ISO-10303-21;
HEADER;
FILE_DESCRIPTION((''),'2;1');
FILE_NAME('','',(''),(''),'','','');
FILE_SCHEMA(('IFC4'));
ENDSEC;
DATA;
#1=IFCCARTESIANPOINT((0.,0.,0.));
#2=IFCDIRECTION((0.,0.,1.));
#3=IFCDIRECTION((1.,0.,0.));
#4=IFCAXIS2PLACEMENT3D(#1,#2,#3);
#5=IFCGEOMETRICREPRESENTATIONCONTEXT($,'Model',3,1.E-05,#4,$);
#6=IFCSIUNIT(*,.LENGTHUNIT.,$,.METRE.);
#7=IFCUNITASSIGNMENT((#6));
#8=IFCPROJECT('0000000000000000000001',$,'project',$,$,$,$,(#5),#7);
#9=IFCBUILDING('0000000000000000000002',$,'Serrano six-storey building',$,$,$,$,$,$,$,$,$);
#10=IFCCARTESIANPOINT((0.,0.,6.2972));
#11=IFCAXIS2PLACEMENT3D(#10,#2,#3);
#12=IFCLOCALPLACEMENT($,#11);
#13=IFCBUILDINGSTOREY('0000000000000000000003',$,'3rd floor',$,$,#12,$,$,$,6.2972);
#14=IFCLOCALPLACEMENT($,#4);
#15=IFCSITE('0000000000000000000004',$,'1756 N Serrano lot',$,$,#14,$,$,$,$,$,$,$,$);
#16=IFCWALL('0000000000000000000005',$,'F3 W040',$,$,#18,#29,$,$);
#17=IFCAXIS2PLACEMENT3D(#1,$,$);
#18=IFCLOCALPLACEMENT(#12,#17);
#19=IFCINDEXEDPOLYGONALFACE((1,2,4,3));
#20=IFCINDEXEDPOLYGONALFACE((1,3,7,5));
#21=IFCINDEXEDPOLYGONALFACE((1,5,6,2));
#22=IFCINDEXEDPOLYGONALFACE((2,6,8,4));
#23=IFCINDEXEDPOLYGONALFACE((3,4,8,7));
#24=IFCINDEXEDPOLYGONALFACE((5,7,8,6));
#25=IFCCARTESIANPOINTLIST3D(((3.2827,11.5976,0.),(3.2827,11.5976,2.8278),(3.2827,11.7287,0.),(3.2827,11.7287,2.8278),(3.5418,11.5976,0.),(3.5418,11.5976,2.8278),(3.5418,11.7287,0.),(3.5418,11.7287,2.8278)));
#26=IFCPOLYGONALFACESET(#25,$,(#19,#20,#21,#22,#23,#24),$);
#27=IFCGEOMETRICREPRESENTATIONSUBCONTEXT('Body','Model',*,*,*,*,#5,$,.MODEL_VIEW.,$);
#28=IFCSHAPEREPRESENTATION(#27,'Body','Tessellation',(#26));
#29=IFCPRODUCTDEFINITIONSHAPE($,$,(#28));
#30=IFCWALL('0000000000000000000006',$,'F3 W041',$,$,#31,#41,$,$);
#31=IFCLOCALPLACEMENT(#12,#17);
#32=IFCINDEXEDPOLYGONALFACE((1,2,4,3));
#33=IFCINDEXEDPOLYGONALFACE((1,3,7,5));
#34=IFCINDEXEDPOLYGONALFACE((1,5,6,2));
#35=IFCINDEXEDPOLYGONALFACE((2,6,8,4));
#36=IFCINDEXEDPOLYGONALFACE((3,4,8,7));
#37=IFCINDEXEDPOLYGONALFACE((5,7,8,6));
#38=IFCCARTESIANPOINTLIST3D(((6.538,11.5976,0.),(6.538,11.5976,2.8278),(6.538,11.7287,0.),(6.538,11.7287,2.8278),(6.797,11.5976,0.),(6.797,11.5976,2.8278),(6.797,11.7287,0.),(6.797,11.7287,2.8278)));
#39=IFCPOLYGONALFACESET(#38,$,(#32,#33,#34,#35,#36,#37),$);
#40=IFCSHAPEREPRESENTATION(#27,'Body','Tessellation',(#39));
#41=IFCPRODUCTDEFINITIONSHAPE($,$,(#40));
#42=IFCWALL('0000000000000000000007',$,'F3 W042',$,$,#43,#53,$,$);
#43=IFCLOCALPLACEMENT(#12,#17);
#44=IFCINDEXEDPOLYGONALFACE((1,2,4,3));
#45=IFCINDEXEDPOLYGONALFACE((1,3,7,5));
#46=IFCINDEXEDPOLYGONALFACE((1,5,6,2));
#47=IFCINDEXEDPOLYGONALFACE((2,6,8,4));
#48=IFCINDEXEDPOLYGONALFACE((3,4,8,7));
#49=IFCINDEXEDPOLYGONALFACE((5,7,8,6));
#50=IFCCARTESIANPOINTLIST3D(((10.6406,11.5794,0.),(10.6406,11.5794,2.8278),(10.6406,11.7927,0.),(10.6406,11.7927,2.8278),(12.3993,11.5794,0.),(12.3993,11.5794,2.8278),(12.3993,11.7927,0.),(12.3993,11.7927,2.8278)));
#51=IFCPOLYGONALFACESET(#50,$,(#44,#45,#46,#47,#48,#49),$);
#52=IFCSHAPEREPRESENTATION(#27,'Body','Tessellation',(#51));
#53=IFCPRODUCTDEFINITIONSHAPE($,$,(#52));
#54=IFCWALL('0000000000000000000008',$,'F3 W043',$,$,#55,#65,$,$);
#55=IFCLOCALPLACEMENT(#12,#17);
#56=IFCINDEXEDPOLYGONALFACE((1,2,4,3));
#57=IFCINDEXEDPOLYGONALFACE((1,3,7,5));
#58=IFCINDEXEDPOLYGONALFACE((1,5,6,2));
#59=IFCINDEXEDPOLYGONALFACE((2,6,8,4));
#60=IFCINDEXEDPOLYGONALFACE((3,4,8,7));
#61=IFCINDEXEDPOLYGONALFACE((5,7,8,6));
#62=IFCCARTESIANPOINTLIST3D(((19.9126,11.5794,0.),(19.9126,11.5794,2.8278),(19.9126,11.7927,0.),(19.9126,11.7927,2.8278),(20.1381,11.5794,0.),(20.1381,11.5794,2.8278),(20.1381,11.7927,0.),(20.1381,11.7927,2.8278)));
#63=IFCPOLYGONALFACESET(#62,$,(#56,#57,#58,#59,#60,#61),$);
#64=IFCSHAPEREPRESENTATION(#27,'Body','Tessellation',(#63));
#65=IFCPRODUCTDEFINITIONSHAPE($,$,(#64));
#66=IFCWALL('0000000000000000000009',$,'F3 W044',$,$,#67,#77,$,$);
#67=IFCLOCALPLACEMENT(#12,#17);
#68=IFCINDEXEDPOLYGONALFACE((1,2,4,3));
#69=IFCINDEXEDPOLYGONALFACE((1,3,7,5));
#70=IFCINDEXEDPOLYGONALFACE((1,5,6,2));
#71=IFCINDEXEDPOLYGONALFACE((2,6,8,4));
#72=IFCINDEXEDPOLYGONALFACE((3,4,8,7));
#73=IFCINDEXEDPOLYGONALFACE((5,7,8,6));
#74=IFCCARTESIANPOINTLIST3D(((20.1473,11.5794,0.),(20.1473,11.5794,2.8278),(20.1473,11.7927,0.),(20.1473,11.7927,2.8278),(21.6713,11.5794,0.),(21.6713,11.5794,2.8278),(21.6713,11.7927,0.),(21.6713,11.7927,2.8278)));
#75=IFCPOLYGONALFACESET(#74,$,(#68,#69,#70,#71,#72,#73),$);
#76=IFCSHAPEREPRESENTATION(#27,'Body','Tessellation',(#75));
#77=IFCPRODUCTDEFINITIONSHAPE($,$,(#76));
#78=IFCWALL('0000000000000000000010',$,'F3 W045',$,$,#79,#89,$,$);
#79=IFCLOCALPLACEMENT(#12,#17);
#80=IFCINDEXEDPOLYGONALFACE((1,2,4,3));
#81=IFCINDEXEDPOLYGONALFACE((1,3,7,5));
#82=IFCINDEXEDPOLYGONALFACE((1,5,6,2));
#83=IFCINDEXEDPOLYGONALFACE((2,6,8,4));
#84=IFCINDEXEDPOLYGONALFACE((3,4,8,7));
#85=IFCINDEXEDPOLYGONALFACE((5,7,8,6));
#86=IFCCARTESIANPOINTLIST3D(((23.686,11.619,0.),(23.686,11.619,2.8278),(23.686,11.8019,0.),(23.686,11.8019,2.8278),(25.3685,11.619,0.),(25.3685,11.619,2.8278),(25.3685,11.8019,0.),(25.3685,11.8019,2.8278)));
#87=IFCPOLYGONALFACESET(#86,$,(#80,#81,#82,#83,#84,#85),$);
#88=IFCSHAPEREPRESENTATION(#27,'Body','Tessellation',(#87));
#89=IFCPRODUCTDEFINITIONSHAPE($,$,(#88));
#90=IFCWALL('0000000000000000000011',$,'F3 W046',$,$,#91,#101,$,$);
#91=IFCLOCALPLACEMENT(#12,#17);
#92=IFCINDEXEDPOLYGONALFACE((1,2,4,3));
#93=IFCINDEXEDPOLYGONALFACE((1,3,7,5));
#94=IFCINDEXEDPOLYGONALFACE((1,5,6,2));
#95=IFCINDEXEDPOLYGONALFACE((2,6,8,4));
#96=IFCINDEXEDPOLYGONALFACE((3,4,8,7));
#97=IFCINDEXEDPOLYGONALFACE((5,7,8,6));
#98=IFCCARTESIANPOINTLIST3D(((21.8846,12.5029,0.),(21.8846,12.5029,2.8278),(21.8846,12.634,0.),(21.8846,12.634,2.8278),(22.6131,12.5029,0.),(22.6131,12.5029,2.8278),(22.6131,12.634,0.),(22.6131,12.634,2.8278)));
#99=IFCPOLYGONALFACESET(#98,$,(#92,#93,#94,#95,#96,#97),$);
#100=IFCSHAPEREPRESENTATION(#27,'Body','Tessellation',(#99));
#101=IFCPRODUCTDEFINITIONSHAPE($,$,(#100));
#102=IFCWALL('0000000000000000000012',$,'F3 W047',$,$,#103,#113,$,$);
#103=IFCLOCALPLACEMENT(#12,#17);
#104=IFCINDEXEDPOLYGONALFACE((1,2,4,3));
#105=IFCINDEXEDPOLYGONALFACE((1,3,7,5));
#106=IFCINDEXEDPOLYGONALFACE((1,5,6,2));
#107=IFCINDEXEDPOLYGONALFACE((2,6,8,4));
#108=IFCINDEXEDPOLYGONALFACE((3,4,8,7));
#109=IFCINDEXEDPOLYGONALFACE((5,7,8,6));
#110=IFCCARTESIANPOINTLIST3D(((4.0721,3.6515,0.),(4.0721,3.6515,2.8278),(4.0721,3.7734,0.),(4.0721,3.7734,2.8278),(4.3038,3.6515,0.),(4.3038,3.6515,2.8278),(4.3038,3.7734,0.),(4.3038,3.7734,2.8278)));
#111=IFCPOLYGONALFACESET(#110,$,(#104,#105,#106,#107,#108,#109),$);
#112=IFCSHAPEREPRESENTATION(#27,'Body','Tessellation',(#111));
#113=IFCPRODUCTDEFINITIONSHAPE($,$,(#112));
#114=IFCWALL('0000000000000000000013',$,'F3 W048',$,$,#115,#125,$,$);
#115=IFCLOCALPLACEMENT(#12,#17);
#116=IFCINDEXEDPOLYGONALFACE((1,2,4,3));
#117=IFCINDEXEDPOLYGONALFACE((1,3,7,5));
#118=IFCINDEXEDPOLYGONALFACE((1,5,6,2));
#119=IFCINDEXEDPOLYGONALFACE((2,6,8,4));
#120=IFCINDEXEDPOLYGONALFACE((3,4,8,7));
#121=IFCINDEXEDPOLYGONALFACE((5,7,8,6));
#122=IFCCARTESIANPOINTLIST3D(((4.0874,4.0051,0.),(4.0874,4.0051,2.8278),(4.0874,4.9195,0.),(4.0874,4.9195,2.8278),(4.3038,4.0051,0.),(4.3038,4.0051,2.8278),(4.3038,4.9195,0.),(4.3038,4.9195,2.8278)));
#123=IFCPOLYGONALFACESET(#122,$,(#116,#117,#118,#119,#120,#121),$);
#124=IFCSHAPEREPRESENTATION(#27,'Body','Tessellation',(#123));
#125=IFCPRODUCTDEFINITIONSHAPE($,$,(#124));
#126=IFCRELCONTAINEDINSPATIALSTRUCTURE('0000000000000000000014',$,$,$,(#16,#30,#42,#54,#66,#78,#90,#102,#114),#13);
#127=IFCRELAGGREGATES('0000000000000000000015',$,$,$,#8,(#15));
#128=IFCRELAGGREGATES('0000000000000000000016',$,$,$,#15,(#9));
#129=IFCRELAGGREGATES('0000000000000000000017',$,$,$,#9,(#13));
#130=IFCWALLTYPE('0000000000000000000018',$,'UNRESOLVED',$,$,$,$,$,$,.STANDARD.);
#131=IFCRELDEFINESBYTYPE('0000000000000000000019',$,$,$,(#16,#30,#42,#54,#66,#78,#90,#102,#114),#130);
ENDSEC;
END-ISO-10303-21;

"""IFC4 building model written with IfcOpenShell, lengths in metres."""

from ifc_helpers import new_model, si_unit, frame, origin_with_axes, place, context, subcontext, project, spatial, polyline, outline, extrude, type_object, element, save


model = new_model("IFC4")

# Units and contexts
model_context = context("Model", 3, precision=1e-05, world=origin_with_axes())
body_context = subcontext(model_context, "Body", "Model", "MODEL_VIEW")
ifc_project = project(units=[si_unit("LENGTHUNIT", "METRE")], contexts=[model_context])

# Site, building, storey
site_placement = place(None, origin_with_axes())
site = spatial("IfcSite", under=ifc_project, at=site_placement, Name="1756 N Serrano lot")
building = spatial("IfcBuilding", under=site, Name="Serrano six-storey building")
storey_placement = place(None, frame((0.0, 0.0, 6.2972), z_axis=(0.0, 0.0, 1.0), x_axis=(1.0, 0.0, 0.0)))
storey = spatial("IfcBuildingStorey", under=building, at=storey_placement, Name="3rd floor", Elevation=6.2972)

# Walls
wall_type_1 = type_object("IfcWallType", Name="UNRESOLVED", PredefinedType="STANDARD")
wall_1_placement = place(storey_placement, frame((0.0, 0.0, -6.2972), z_axis=(0.0, 0.0, 1.0), x_axis=(1.0, 0.0, 0.0)))
element("IfcWall", 1, at=wall_1_placement, inside=storey, type_object=wall_type_1, Name="F3 W040", context=body_context, shape_type="SweptSolid", body=[
    extrude(outline(polyline([(3.5418, 11.7287), (3.5418, 11.5976), (3.2827, 11.5976), (3.2827, 11.7287), (3.5418, 11.7287)])), frame((0.0, 0.0, 6.2972)), (0.0, 0.0, 1.0), 2.8278),
])
wall_2_placement = place(storey_placement, frame((0.0, 0.0, -6.2972), z_axis=(0.0, 0.0, 1.0), x_axis=(1.0, 0.0, 0.0)))
element("IfcWall", 2, at=wall_2_placement, inside=storey, type_object=wall_type_1, Name="F3 W041", context=body_context, shape_type="SweptSolid", body=[
    extrude(outline(polyline([(6.797, 11.7287), (6.797, 11.5976), (6.538, 11.5976), (6.538, 11.7287), (6.797, 11.7287)])), frame((0.0, 0.0, 6.2972)), (0.0, 0.0, 1.0), 2.8278),
])
wall_3_placement = place(storey_placement, frame((0.0, 0.0, -6.2972), z_axis=(0.0, 0.0, 1.0), x_axis=(1.0, 0.0, 0.0)))
element("IfcWall", 3, at=wall_3_placement, inside=storey, type_object=wall_type_1, Name="F3 W042", context=body_context, shape_type="SweptSolid", body=[
    extrude(outline(polyline([(12.3993, 11.7927), (12.3993, 11.5794), (10.6406, 11.5794), (10.6406, 11.7927), (12.3993, 11.7927)])), frame((0.0, 0.0, 6.2972)), (0.0, 0.0, 1.0), 2.8278),
])
wall_4_placement = place(storey_placement, frame((0.0, 0.0, -6.2972), z_axis=(0.0, 0.0, 1.0), x_axis=(1.0, 0.0, 0.0)))
element("IfcWall", 4, at=wall_4_placement, inside=storey, type_object=wall_type_1, Name="F3 W043", context=body_context, shape_type="SweptSolid", body=[
    extrude(outline(polyline([(20.1381, 11.7927), (20.1381, 11.5794), (19.9126, 11.5794), (19.9126, 11.7927), (20.1381, 11.7927)])), frame((0.0, 0.0, 6.2972)), (0.0, 0.0, 1.0), 2.8278),
])
wall_5_placement = place(storey_placement, frame((0.0, 0.0, -6.2972), z_axis=(0.0, 0.0, 1.0), x_axis=(1.0, 0.0, 0.0)))
element("IfcWall", 5, at=wall_5_placement, inside=storey, type_object=wall_type_1, Name="F3 W044", context=body_context, shape_type="SweptSolid", body=[
    extrude(outline(polyline([(21.6713, 11.7927), (21.6713, 11.5794), (20.1473, 11.5794), (20.1473, 11.7927), (21.6713, 11.7927)])), frame((0.0, 0.0, 6.2972)), (0.0, 0.0, 1.0), 2.8278),
])
wall_6_placement = place(storey_placement, frame((0.0, 0.0, -6.2972), z_axis=(0.0, 0.0, 1.0), x_axis=(1.0, 0.0, 0.0)))
element("IfcWall", 6, at=wall_6_placement, inside=storey, type_object=wall_type_1, Name="F3 W045", context=body_context, shape_type="SweptSolid", body=[
    extrude(outline(polyline([(25.3685, 11.8019), (25.3685, 11.619), (23.686, 11.619), (23.686, 11.8019), (25.3685, 11.8019)])), frame((0.0, 0.0, 6.2972)), (0.0, 0.0, 1.0), 2.8278),
])
wall_7_placement = place(storey_placement, frame((0.0, 0.0, -6.2972), z_axis=(0.0, 0.0, 1.0), x_axis=(1.0, 0.0, 0.0)))
element("IfcWall", 7, at=wall_7_placement, inside=storey, type_object=wall_type_1, Name="F3 W046", context=body_context, shape_type="SweptSolid", body=[
    extrude(outline(polyline([(22.6131, 12.634), (22.6131, 12.5029), (21.8846, 12.5029), (21.8846, 12.634), (22.6131, 12.634)])), frame((0.0, 0.0, 6.2972)), (0.0, 0.0, 1.0), 2.8278),
])
wall_8_placement = place(storey_placement, frame((0.0, 0.0, -6.2972), z_axis=(0.0, 0.0, 1.0), x_axis=(1.0, 0.0, 0.0)))
element("IfcWall", 8, at=wall_8_placement, inside=storey, type_object=wall_type_1, Name="F3 W047", context=body_context, shape_type="SweptSolid", body=[
    extrude(outline(polyline([(4.0721, 3.7734), (4.3038, 3.7734), (4.3038, 3.6515), (4.0721, 3.6515), (4.0721, 3.7734)])), frame((0.0, 0.0, 6.2972)), (0.0, 0.0, 1.0), 2.8278),
])
wall_9_placement = place(storey_placement, frame((0.0, 0.0, -6.2972), z_axis=(0.0, 0.0, 1.0), x_axis=(1.0, 0.0, 0.0)))
element("IfcWall", 9, at=wall_9_placement, inside=storey, type_object=wall_type_1, Name="F3 W048", context=body_context, shape_type="SweptSolid", body=[
    extrude(outline(polyline([(4.0874, 4.9195), (4.3038, 4.9195), (4.3038, 4.0051), (4.0874, 4.0051), (4.0874, 4.9195)])), frame((0.0, 0.0, 6.2972)), (0.0, 0.0, 1.0), 2.8278),
])

save(model, "model.ifc")
